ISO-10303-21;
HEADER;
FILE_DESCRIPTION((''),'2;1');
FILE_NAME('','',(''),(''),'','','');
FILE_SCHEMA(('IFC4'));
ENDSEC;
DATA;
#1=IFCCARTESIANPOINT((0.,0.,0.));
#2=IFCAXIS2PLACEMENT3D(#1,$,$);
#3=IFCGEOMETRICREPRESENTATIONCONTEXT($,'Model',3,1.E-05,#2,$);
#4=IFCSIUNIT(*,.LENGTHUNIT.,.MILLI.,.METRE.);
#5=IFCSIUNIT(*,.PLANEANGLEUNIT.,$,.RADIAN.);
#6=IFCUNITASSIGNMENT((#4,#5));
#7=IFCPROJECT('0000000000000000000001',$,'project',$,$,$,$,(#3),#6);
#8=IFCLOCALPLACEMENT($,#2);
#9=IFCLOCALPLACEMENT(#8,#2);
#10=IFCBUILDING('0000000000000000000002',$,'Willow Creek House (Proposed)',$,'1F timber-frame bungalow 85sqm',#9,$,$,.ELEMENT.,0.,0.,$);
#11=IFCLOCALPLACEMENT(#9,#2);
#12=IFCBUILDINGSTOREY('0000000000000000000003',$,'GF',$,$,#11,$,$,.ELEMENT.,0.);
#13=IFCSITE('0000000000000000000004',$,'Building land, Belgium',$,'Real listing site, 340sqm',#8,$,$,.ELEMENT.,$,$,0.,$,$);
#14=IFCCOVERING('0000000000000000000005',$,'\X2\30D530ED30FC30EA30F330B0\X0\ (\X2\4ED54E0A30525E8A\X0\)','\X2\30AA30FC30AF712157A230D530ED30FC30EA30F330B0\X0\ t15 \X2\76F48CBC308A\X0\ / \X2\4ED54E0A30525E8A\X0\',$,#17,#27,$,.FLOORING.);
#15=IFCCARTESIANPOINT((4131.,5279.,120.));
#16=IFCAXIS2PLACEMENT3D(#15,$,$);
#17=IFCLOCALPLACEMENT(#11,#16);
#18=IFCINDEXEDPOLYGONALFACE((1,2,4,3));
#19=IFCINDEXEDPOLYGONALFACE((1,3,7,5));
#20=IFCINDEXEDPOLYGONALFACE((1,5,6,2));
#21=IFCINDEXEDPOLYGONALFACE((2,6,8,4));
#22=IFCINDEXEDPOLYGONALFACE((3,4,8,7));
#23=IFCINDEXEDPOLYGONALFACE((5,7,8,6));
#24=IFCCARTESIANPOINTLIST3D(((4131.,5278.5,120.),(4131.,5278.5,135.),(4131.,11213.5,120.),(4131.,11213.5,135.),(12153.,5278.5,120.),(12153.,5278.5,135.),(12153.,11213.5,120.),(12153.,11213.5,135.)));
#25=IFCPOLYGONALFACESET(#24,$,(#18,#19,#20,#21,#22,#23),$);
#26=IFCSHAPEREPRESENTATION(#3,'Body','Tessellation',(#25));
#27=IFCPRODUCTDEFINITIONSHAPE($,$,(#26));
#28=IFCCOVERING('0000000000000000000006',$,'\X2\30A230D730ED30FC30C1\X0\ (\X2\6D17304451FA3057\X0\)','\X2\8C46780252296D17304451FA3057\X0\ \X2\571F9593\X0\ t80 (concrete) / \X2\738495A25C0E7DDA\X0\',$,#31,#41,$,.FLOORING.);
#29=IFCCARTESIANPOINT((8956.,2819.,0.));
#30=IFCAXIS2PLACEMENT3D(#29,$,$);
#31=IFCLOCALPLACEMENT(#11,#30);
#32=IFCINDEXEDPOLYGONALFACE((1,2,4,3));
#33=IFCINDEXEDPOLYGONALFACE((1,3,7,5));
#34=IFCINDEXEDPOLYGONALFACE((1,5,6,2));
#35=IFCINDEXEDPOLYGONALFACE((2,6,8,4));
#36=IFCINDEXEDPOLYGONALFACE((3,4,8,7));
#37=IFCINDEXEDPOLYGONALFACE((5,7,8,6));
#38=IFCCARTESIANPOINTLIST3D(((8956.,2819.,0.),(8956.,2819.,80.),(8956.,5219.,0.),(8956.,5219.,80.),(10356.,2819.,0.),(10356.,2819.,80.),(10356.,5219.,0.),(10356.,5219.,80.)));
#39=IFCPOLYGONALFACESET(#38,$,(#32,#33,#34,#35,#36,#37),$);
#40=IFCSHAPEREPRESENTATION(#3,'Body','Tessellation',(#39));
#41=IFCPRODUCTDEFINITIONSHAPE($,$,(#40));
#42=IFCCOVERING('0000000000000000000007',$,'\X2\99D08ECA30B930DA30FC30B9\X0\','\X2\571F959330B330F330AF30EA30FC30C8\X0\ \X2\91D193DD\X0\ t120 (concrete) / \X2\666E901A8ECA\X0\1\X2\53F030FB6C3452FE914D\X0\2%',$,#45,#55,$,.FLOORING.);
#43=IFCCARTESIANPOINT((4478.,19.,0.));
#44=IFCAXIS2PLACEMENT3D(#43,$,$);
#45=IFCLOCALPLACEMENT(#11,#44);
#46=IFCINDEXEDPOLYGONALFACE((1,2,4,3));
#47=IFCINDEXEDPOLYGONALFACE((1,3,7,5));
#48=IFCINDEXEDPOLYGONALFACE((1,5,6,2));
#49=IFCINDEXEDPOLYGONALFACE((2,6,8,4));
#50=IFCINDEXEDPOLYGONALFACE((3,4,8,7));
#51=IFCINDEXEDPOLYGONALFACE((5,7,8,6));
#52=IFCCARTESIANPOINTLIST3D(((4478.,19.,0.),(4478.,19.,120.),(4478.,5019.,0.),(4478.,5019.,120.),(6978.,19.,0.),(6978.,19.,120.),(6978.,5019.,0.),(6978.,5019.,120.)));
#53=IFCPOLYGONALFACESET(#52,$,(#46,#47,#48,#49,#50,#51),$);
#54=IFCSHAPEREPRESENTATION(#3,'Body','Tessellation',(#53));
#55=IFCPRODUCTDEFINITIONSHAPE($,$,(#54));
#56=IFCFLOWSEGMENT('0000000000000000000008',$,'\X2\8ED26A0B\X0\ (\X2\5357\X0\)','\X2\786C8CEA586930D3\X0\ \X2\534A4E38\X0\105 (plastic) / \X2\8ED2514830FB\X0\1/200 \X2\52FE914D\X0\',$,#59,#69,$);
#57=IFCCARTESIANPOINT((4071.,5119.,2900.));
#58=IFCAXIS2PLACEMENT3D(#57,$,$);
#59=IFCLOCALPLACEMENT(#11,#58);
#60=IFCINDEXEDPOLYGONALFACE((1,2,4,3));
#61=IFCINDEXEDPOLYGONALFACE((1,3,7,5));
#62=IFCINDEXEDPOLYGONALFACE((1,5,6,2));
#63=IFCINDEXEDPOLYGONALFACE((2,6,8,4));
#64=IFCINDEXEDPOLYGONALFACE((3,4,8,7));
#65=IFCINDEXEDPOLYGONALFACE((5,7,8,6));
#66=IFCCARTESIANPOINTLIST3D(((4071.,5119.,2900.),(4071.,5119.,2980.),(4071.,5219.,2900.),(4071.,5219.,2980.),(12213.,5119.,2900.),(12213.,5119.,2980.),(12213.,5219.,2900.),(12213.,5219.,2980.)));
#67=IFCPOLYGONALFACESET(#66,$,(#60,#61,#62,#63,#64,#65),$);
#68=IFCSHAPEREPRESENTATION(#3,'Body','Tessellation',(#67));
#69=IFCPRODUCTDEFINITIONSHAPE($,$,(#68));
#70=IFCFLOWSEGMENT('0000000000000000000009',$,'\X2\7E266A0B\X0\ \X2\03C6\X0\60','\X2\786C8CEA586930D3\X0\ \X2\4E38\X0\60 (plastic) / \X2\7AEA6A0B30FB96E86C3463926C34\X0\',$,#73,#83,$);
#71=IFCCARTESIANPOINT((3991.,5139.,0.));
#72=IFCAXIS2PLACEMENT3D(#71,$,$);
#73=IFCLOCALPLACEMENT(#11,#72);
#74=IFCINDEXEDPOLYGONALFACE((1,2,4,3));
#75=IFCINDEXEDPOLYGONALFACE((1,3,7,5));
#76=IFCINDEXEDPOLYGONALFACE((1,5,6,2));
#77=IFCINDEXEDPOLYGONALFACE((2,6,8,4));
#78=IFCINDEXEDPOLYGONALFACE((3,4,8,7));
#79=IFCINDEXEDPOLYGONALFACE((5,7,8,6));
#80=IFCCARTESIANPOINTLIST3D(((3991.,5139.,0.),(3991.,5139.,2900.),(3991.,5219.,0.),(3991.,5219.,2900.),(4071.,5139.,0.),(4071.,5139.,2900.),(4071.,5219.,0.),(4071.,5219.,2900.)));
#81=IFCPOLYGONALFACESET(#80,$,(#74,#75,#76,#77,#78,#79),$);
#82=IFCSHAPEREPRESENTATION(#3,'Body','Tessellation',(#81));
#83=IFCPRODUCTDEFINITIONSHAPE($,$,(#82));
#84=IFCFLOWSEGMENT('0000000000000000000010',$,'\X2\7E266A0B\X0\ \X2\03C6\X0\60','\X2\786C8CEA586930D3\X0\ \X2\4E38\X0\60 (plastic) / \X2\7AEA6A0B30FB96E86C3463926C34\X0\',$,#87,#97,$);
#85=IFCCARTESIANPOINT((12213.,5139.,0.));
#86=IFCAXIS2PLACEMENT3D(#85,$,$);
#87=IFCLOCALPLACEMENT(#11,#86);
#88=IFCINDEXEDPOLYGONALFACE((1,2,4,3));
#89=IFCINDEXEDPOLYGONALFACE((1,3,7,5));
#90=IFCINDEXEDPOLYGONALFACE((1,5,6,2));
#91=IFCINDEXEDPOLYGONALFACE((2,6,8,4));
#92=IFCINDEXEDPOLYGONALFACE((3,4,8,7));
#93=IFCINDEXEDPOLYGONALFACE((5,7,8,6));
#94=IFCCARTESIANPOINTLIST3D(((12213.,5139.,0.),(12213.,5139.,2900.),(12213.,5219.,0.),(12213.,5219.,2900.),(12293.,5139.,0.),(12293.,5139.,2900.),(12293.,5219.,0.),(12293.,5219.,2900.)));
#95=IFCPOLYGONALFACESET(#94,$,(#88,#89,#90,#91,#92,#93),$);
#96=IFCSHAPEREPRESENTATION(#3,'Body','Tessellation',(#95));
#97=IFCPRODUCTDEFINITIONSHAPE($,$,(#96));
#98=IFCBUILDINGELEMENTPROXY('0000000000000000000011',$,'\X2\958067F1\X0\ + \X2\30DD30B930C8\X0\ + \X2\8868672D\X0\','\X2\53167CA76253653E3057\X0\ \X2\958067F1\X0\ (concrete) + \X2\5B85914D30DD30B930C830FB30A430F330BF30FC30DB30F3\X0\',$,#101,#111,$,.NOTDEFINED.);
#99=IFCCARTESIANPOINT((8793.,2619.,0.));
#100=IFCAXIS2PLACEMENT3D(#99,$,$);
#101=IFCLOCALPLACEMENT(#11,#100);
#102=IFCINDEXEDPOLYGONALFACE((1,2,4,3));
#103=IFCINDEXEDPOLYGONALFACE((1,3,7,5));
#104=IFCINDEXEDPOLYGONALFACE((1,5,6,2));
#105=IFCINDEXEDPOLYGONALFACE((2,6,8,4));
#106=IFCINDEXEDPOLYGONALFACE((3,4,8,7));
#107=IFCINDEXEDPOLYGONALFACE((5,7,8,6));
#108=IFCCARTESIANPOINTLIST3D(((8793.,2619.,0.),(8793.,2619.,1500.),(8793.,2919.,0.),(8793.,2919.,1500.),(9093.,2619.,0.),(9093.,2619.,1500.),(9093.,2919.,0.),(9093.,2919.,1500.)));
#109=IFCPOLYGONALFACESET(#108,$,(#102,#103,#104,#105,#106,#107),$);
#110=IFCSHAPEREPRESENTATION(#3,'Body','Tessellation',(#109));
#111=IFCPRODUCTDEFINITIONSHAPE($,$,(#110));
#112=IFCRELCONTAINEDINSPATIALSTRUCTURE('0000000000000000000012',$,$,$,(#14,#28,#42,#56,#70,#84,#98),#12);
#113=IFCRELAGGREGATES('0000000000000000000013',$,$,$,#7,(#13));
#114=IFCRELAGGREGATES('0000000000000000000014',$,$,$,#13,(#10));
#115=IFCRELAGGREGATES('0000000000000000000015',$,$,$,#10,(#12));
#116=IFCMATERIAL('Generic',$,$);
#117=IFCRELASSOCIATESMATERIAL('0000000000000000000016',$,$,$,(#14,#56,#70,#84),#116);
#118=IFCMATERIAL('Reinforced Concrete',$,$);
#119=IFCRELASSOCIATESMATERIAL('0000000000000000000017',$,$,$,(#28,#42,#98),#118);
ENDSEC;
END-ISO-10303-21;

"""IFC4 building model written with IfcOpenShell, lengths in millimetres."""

from ifc_helpers import new_model, si_unit, frame, frame_2d, origin, place, context, project, spatial, rectangle, extrude, material, element, save


model = new_model("IFC4")

# Units and contexts
model_context = context("Model", 3, precision=1e-05, world=origin())
ifc_project = project(units=[si_unit("LENGTHUNIT", "METRE", prefix="MILLI"), si_unit("PLANEANGLEUNIT", "RADIAN")], contexts=[model_context])

# Site, building, storey
site_placement = place(None, origin())
site = spatial("IfcSite", under=ifc_project, at=site_placement, Name="Building land, Belgium", ObjectType="Real listing site, 340sqm", CompositionType="ELEMENT", RefElevation=0.0)
building_placement = place(site_placement, origin())
building = spatial("IfcBuilding", under=site, at=building_placement, Name="Willow Creek House (Proposed)", ObjectType="1F timber-frame bungalow 85sqm", CompositionType="ELEMENT", ElevationOfRefHeight=0.0, ElevationOfTerrain=0.0)
storey_placement = place(building_placement, origin())
storey = spatial("IfcBuildingStorey", under=building, at=storey_placement, Name="GF", CompositionType="ELEMENT", Elevation=0.0)

# Shared definitions
ifc_material_1 = material(Name="Reinforced Concrete")

# Coverings
ifc_material_2 = material(Name="Generic")
covering_1_placement = place(storey_placement, frame((4131.0, 5279.0, 120.0)))
element("IfcCovering", 1, at=covering_1_placement, inside=storey, material=ifc_material_2, Name="フローリング (仕上げ床)", Description="オーク無垢フローリング t15 直貼り / 仕上げ床", PredefinedType="FLOORING", context=model_context, shape_type="SweptSolid", body=[
    extrude(rectangle(XDim=8022.0, YDim=5935.0, at=frame_2d((4011.0, 2967.0))), frame((4131.0, 5279.0, 120.0)), (0.0, 0.0, 1.0), 15.0),
])
covering_2_placement = place(storey_placement, frame((8956.0, 2819.0, 0.0)))
element("IfcCovering", 2, at=covering_2_placement, inside=storey, material=ifc_material_1, Name="アプローチ (洗い出し)", Description="豆砂利洗い出し 土間 t80 (concrete) / 玄関導線", PredefinedType="FLOORING", context=model_context, shape_type="SweptSolid", body=[
    extrude(rectangle(XDim=1400.0, YDim=2400.0, at=frame_2d((700.0, 1200.0))), frame((8956.0, 2819.0, 0.0)), (0.0, 0.0, 1.0), 80.0),
])
covering_3_placement = place(storey_placement, frame((4478.0, 19.0, 0.0)))
element("IfcCovering", 3, at=covering_3_placement, inside=storey, material=ifc_material_1, Name="駐車スペース", Description="土間コンクリート 金鏝 t120 (concrete) / 普通車1台・水勾配2%", PredefinedType="FLOORING", context=model_context, shape_type="SweptSolid", body=[
    extrude(rectangle(XDim=2500.0, YDim=5000.0, at=frame_2d((1250.0, 2500.0))), frame((4478.0, 19.0, 0.0)), (0.0, 0.0, 1.0), 120.0),
])

# Flow segments
flow_segment_1_placement = place(storey_placement, frame((4071.0, 5119.0, 2900.0)))
element("IfcFlowSegment", 4, at=flow_segment_1_placement, inside=storey, material=ifc_material_2, Name="軒樋 (南)", Description="硬質塩ビ 半丸105 (plastic) / 軒先・1/200 勾配", context=model_context, shape_type="SweptSolid", body=[
    extrude(rectangle(XDim=8142.0, YDim=100.0, at=frame_2d((4071.0, 50.0))), frame((4071.0, 5119.0, 2900.0)), (0.0, 0.0, 1.0), 80.0),
])
flow_segment_2_placement = place(storey_placement, frame((3991.0, 5139.0, 0.0)))
element("IfcFlowSegment", 5, at=flow_segment_2_placement, inside=storey, material=ifc_material_2, Name="縦樋 φ60", Description="硬質塩ビ 丸60 (plastic) / 竪樋・雨水排水", context=model_context, shape_type="SweptSolid", body=[
    extrude(rectangle(XDim=80.0, YDim=80.0, at=frame_2d((40.0, 40.0))), frame((3991.0, 5139.0, 0.0)), (0.0, 0.0, 1.0), 2900.0),
])
flow_segment_3_placement = place(storey_placement, frame((12213.0, 5139.0, 0.0)))
element("IfcFlowSegment", 6, at=flow_segment_3_placement, inside=storey, material=ifc_material_2, Name="縦樋 φ60", Description="硬質塩ビ 丸60 (plastic) / 竪樋・雨水排水", context=model_context, shape_type="SweptSolid", body=[
    extrude(rectangle(XDim=80.0, YDim=80.0, at=frame_2d((40.0, 40.0))), frame((12213.0, 5139.0, 0.0)), (0.0, 0.0, 1.0), 2900.0),
])

# Building element proxy
proxy_placement = place(storey_placement, frame((8793.0, 2619.0, 0.0)))
element("IfcBuildingElementProxy", 7, at=proxy_placement, inside=storey, material=ifc_material_1, Name="門柱 + ポスト + 表札", Description="化粧打放し 門柱 (concrete) + 宅配ポスト・インターホン", PredefinedType="NOTDEFINED", context=model_context, shape_type="SweptSolid", body=[
    extrude(rectangle(XDim=300.0, YDim=300.0, at=frame_2d((150.0, 150.0))), frame((8793.0, 2619.0, 0.0)), (0.0, 0.0, 1.0), 1500.0),
])

save(model, "model.ifc")
